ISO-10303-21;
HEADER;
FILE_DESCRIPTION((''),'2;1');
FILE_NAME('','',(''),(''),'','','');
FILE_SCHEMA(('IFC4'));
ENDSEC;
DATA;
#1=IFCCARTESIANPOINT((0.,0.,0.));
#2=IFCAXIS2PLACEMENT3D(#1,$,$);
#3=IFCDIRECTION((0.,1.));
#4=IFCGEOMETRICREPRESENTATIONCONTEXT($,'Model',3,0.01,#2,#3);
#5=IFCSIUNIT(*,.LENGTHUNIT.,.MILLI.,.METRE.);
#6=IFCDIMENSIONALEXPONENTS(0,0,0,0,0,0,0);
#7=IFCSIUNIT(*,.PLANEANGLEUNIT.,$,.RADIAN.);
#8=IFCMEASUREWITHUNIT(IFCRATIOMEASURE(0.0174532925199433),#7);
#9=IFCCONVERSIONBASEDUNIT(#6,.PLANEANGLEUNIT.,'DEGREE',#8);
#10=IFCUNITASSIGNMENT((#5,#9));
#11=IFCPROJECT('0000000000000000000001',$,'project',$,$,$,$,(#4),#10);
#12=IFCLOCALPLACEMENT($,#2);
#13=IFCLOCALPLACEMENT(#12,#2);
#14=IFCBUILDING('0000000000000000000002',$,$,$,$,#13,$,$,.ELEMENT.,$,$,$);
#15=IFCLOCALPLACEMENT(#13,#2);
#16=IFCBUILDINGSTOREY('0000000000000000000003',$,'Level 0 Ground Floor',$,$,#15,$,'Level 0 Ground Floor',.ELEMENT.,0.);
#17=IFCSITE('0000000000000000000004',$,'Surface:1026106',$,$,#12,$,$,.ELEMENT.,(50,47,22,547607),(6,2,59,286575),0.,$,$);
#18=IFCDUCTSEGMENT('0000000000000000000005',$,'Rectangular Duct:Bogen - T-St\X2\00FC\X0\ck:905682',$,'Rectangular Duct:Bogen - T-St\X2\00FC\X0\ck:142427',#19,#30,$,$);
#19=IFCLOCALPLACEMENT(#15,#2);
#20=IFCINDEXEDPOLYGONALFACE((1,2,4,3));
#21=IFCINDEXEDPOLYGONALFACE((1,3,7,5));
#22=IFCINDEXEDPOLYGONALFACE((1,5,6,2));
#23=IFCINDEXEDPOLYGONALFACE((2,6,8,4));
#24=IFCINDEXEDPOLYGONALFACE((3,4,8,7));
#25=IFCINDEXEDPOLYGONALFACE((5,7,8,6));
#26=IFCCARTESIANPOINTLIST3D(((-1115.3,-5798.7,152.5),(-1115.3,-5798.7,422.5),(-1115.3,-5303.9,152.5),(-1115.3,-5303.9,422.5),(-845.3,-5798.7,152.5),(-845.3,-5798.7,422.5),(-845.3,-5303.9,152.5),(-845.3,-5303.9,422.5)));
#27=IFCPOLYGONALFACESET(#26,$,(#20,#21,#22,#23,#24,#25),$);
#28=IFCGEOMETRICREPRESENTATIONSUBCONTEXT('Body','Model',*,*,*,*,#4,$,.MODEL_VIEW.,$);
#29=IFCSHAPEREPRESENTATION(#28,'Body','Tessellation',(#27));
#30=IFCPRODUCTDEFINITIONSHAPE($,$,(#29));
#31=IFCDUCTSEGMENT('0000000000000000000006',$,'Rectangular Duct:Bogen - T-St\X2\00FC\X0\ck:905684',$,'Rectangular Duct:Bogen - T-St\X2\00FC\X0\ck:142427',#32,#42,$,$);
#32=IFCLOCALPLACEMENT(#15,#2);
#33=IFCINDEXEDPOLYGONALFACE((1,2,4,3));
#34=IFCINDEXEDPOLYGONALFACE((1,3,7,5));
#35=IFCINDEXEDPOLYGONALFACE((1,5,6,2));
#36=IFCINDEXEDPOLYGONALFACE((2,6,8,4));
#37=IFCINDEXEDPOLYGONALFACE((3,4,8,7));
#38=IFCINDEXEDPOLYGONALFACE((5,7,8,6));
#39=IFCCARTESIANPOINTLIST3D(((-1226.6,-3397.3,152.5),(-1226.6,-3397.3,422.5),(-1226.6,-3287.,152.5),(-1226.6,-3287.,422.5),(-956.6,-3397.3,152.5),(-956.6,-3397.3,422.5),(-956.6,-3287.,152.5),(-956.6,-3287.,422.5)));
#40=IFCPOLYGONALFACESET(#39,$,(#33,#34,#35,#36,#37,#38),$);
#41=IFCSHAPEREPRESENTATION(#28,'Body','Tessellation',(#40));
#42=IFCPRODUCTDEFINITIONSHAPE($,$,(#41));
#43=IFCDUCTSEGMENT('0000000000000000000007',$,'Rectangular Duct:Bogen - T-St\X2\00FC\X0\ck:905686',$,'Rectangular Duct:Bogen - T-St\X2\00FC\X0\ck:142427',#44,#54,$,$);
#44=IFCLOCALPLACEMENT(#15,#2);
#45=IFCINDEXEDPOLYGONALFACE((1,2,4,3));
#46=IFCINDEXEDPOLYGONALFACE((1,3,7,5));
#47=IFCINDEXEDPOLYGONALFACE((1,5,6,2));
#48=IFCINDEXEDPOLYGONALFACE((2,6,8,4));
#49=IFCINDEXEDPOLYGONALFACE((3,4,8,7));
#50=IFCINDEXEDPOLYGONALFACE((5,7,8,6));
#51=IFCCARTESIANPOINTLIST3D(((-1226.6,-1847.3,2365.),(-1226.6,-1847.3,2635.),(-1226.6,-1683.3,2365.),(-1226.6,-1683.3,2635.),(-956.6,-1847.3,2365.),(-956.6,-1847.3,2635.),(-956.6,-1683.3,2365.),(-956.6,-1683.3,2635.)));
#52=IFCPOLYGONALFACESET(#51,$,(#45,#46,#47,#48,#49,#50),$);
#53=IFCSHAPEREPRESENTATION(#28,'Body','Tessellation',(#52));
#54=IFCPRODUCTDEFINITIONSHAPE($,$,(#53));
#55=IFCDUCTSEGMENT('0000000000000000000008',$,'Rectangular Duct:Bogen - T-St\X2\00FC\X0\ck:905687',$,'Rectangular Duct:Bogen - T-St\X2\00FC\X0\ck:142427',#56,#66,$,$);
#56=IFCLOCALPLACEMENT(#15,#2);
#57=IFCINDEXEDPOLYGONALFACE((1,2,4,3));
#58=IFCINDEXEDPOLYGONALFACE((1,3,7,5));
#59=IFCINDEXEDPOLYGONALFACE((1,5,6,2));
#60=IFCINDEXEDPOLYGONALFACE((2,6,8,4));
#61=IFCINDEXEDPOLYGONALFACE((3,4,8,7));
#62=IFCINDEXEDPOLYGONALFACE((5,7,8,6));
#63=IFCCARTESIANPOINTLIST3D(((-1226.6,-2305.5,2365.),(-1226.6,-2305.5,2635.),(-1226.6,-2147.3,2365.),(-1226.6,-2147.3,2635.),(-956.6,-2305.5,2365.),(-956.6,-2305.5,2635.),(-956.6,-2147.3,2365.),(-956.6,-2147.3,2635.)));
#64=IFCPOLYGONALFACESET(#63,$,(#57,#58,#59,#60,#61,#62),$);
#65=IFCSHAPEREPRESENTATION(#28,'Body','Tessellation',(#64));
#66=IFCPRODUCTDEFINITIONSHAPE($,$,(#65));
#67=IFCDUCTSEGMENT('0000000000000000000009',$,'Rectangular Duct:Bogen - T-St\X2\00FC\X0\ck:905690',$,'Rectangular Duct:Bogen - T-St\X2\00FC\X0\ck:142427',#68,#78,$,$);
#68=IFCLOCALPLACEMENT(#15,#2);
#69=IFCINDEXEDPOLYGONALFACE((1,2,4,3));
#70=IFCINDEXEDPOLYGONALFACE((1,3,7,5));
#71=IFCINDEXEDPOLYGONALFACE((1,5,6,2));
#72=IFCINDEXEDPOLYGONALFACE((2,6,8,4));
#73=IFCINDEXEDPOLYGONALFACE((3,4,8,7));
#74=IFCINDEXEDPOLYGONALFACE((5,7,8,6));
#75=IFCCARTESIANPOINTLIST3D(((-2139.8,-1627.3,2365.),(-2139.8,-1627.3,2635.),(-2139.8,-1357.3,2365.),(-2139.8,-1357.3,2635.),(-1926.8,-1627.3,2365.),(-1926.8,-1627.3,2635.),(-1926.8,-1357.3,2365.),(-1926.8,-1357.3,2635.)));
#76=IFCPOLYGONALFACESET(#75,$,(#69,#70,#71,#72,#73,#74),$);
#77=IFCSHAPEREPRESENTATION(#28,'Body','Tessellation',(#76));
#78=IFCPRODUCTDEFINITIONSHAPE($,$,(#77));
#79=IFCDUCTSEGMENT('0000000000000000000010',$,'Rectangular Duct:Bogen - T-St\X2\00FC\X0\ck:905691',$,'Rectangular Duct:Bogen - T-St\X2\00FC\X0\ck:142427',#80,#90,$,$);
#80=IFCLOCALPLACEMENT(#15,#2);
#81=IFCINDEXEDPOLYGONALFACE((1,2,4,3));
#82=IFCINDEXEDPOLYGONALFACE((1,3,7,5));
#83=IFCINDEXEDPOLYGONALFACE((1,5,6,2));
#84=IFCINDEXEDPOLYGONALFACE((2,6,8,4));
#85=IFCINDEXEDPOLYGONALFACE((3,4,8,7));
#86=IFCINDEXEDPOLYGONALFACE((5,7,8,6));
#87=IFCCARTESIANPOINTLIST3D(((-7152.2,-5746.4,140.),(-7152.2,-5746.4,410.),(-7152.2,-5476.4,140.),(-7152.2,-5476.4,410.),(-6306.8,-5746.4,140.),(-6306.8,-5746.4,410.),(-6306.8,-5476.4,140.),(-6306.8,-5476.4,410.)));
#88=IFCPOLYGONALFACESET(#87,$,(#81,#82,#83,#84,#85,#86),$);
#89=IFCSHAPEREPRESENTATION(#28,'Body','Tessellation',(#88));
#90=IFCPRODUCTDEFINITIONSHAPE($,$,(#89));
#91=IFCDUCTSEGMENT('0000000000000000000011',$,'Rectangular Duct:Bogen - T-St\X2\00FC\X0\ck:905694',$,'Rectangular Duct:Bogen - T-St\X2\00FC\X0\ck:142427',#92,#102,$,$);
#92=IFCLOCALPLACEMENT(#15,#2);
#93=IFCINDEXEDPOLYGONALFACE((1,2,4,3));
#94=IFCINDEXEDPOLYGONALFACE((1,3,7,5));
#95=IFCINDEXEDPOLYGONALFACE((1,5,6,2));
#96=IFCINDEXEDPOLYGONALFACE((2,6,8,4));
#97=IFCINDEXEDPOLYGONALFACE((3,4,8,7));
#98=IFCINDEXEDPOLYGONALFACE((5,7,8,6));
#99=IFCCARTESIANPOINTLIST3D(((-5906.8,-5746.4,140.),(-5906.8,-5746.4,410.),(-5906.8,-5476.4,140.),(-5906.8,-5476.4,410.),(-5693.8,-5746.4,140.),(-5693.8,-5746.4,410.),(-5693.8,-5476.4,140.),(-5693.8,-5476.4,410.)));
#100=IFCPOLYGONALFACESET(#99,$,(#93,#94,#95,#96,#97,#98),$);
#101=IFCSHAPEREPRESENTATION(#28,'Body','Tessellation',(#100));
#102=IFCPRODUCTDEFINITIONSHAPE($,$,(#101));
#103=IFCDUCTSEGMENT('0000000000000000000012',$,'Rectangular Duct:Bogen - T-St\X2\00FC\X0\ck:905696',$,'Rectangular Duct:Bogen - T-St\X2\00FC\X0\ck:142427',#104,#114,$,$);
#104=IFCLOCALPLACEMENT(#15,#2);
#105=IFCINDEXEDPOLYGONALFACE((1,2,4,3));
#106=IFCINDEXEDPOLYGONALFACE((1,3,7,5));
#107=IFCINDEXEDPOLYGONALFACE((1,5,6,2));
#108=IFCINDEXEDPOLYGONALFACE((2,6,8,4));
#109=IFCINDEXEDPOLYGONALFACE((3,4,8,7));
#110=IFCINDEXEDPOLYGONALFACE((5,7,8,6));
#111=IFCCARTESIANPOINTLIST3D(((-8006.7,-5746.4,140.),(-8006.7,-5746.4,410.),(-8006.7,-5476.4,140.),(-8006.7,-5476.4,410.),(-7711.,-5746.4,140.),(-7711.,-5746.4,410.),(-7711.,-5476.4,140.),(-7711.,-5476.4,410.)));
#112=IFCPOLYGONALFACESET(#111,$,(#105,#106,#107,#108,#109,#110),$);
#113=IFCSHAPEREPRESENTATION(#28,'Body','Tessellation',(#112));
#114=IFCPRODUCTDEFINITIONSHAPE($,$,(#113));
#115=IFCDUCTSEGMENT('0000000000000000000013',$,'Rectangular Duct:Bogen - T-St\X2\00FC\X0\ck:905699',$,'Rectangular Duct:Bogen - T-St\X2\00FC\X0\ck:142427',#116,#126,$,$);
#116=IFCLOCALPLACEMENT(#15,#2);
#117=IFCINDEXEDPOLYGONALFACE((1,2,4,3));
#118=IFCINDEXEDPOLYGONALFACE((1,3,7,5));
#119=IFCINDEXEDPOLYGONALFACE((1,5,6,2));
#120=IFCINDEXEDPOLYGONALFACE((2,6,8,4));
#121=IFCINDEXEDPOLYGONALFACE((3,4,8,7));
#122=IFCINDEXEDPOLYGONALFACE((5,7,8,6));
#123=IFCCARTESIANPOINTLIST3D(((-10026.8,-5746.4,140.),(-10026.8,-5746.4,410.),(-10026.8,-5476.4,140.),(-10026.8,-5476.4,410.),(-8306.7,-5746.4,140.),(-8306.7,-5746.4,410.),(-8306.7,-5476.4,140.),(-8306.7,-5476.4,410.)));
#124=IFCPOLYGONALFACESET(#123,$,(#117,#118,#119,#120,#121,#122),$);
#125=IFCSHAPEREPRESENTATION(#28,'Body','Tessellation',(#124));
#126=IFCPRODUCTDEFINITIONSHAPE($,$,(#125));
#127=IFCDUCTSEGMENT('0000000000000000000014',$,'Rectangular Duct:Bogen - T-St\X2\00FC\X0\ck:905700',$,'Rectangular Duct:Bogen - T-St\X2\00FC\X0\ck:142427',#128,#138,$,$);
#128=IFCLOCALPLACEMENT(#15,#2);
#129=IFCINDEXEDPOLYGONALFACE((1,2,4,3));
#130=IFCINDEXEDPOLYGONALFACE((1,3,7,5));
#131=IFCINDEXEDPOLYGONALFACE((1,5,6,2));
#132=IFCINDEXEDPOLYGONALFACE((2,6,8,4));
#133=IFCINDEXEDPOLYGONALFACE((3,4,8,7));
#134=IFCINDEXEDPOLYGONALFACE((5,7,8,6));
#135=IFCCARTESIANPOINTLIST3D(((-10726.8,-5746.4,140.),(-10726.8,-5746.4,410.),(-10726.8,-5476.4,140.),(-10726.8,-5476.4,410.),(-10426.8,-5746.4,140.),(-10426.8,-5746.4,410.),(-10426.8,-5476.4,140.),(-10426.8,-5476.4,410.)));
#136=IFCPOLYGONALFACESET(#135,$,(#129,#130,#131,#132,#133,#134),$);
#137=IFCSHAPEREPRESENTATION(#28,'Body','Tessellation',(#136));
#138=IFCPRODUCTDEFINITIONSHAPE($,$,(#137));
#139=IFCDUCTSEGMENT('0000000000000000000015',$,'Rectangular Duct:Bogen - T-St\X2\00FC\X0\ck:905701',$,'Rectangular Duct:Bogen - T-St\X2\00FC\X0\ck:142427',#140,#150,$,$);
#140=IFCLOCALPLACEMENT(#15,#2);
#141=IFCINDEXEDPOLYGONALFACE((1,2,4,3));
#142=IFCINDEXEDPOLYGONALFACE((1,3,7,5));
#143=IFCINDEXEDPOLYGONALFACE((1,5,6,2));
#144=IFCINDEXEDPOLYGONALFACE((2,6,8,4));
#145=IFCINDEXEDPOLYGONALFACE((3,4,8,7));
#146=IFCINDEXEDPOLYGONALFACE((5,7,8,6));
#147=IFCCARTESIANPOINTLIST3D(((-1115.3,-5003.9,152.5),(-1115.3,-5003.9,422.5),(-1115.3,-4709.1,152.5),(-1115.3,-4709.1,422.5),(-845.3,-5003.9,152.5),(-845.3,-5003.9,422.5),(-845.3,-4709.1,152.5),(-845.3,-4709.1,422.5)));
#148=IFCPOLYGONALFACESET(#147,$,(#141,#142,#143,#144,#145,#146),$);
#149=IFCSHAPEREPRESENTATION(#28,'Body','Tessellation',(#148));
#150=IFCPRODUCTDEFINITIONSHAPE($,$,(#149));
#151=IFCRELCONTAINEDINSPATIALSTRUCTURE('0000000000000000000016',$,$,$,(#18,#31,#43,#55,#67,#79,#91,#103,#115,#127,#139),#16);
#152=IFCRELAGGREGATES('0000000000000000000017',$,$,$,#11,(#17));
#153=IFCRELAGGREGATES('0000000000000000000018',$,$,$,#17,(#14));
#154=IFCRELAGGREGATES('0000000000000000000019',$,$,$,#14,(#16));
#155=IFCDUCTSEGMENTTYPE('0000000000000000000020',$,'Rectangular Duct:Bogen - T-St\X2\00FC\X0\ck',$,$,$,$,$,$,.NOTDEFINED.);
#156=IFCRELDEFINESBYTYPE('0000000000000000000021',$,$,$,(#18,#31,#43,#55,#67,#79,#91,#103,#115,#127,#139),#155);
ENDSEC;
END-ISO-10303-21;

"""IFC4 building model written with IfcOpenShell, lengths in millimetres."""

from ifc_helpers import new_model, entity, si_unit, converted_unit, direction, frame, frame_2d, origin, origin_2d_with_axis, place, context, subcontext, project, spatial, rectangle, extrude, type_object, element, save


model = new_model("IFC4")

# Units and contexts
model_context = context("Model", 3, precision=0.01, world=origin(), true_north=direction((0.0, 1.0)))
body_context = subcontext(model_context, "Body", "Model", "MODEL_VIEW")
ifc_project = project(units=[si_unit("LENGTHUNIT", "METRE", prefix="MILLI"), converted_unit("PLANEANGLEUNIT", "DEGREE", entity("IfcRatioMeasure", 0.0174532925199433), si_unit("PLANEANGLEUNIT", "RADIAN"), dimensions=[0, 0, 0, 0, 0, 0, 0])], contexts=[model_context])

# Site, building, storey
site_placement = place(None, origin())
site = spatial("IfcSite", under=ifc_project, at=site_placement, Name="Surface:1026106", CompositionType="ELEMENT", RefLatitude=(50, 47, 22, 547607), RefLongitude=(6, 2, 59, 286575), RefElevation=0.0)
building_placement = place(site_placement, origin())
building = spatial("IfcBuilding", under=site, at=building_placement, CompositionType="ELEMENT")
storey_placement = place(building_placement, origin())
storey = spatial("IfcBuildingStorey", under=building, at=storey_placement, Name="Level 0 Ground Floor", LongName="Level 0 Ground Floor", CompositionType="ELEMENT", Elevation=0.0)

# Duct segments
duct_segment_type = type_object("IfcDuctSegmentType", Name="Rectangular Duct:Bogen - T-Stück", PredefinedType="NOTDEFINED")
duct_segment_1_placement = place(storey_placement, frame((-1115.3, -5798.7, 152.5)))
element("IfcDuctSegment", 1, at=duct_segment_1_placement, inside=storey, type_object=duct_segment_type, Name="Rectangular Duct:Bogen - T-Stück:905682", ObjectType="Rectangular Duct:Bogen - T-Stück:142427", context=body_context, shape_type="SweptSolid", body=[
    extrude(rectangle(XDim=494.8, YDim=270.0, at=frame_2d((0.0, 0.0), x_axis=(1.0, 0.0))), frame((135.0, 247.4, 0.0), z_axis=(0.0, 0.0, 1.0), x_axis=(0.0, -1.0, 0.0)), (0.0, 0.0, 1.0), 270.0),
])
duct_segment_2_placement = place(storey_placement, frame((-1226.6, -3397.3, 152.5)))
element("IfcDuctSegment", 2, at=duct_segment_2_placement, inside=storey, type_object=duct_segment_type, Name="Rectangular Duct:Bogen - T-Stück:905684", ObjectType="Rectangular Duct:Bogen - T-Stück:142427", context=body_context, shape_type="SweptSolid", body=[
    extrude(rectangle(XDim=110.2, YDim=270.0, at=origin_2d_with_axis()), frame((135.0, 55.1, 0.0), z_axis=(0.0, 0.0, 1.0), x_axis=(0.0, 1.0, 0.0)), (0.0, 0.0, 1.0), 270.0),
])
duct_segment_3_placement = place(storey_placement, frame((-1226.6, -1847.3, 2365.0)))
element("IfcDuctSegment", 3, at=duct_segment_3_placement, inside=storey, type_object=duct_segment_type, Name="Rectangular Duct:Bogen - T-Stück:905686", ObjectType="Rectangular Duct:Bogen - T-Stück:142427", context=body_context, shape_type="SweptSolid", body=[
    extrude(rectangle(XDim=164.0, YDim=270.0, at=frame_2d((0.0, 0.0), x_axis=(1.0, 0.0))), frame((135.0, 82.0, 0.0), z_axis=(0.0, 0.0, 1.0), x_axis=(0.0, -1.0, 0.0)), (0.0, 0.0, 1.0), 270.0),
])
duct_segment_4_placement = place(storey_placement, frame((-1226.6, -2305.5, 2365.0)))
element("IfcDuctSegment", 4, at=duct_segment_4_placement, inside=storey, type_object=duct_segment_type, Name="Rectangular Duct:Bogen - T-Stück:905687", ObjectType="Rectangular Duct:Bogen - T-Stück:142427", context=body_context, shape_type="SweptSolid", body=[
    extrude(rectangle(XDim=158.2, YDim=270.0, at=frame_2d((0.0, 0.0), x_axis=(1.0, 0.0))), frame((135.0, 79.1, 0.0), z_axis=(0.0, 0.0, 1.0), x_axis=(0.0, 1.0, 0.0)), (0.0, 0.0, 1.0), 270.0),
])
duct_segment_5_placement = place(storey_placement, frame((-2139.8, -1627.3, 2365.0)))
element("IfcDuctSegment", 5, at=duct_segment_5_placement, inside=storey, type_object=duct_segment_type, Name="Rectangular Duct:Bogen - T-Stück:905690", ObjectType="Rectangular Duct:Bogen - T-Stück:142427", context=body_context, shape_type="SweptSolid", body=[
    extrude(rectangle(XDim=213.0, YDim=270.0, at=origin_2d_with_axis()), frame((106.5, 135.0, 0.0)), (0.0, 0.0, 1.0), 270.0),
])
duct_segment_6_placement = place(storey_placement, frame((-7152.2, -5746.4, 140.0)))
element("IfcDuctSegment", 6, at=duct_segment_6_placement, inside=storey, type_object=duct_segment_type, Name="Rectangular Duct:Bogen - T-Stück:905691", ObjectType="Rectangular Duct:Bogen - T-Stück:142427", context=body_context, shape_type="SweptSolid", body=[
    extrude(rectangle(XDim=845.4, YDim=270.0, at=frame_2d((0.0, 0.0), x_axis=(1.0, 0.0))), frame((422.7, 135.0, 0.0), z_axis=(0.0, 0.0, 1.0), x_axis=(-1.0, 0.0, 0.0)), (0.0, 0.0, 1.0), 270.0),
])
duct_segment_7_placement = place(storey_placement, frame((-5906.8, -5746.4, 140.0)))
element("IfcDuctSegment", 7, at=duct_segment_7_placement, inside=storey, type_object=duct_segment_type, Name="Rectangular Duct:Bogen - T-Stück:905694", ObjectType="Rectangular Duct:Bogen - T-Stück:142427", context=body_context, shape_type="SweptSolid", body=[
    extrude(rectangle(XDim=213.0, YDim=270.0, at=frame_2d((0.0, 0.0), x_axis=(1.0, 0.0))), frame((106.5, 135.0, 0.0), z_axis=(0.0, 0.0, 1.0), x_axis=(-1.0, 0.0, 0.0)), (0.0, 0.0, 1.0), 270.0),
])
duct_segment_8_placement = place(storey_placement, frame((-8006.7, -5746.4, 140.0)))
element("IfcDuctSegment", 8, at=duct_segment_8_placement, inside=storey, type_object=duct_segment_type, Name="Rectangular Duct:Bogen - T-Stück:905696", ObjectType="Rectangular Duct:Bogen - T-Stück:142427", context=body_context, shape_type="SweptSolid", body=[
    extrude(rectangle(XDim=295.7, YDim=270.0, at=frame_2d((0.0, 0.0), x_axis=(1.0, 0.0))), frame((147.8, 135.0, 0.0)), (0.0, 0.0, 1.0), 270.0),
])
duct_segment_9_placement = place(storey_placement, frame((-10026.8, -5746.4, 140.0)))
element("IfcDuctSegment", 9, at=duct_segment_9_placement, inside=storey, type_object=duct_segment_type, Name="Rectangular Duct:Bogen - T-Stück:905699", ObjectType="Rectangular Duct:Bogen - T-Stück:142427", context=body_context, shape_type="SweptSolid", body=[
    extrude(rectangle(XDim=1720.1, YDim=270.0, at=frame_2d((0.0, 0.0), x_axis=(1.0, 0.0))), frame((860.0, 135.0, 0.0)), (0.0, 0.0, 1.0), 270.0),
])
duct_segment_10_placement = place(storey_placement, frame((-10726.8, -5746.4, 140.0)))
element("IfcDuctSegment", 10, at=duct_segment_10_placement, inside=storey, type_object=duct_segment_type, Name="Rectangular Duct:Bogen - T-Stück:905700", ObjectType="Rectangular Duct:Bogen - T-Stück:142427", context=body_context, shape_type="SweptSolid", body=[
    extrude(rectangle(XDim=300.0, YDim=270.0, at=frame_2d((0.0, 0.0), x_axis=(1.0, 0.0))), frame((150.0, 135.0, 0.0)), (0.0, 0.0, 1.0), 270.0),
])
duct_segment_11_placement = place(storey_placement, frame((-1115.3, -5003.9, 152.5)))
element("IfcDuctSegment", 11, at=duct_segment_11_placement, inside=storey, type_object=duct_segment_type, Name="Rectangular Duct:Bogen - T-Stück:905701", ObjectType="Rectangular Duct:Bogen - T-Stück:142427", context=body_context, shape_type="SweptSolid", body=[
    extrude(rectangle(XDim=294.8, YDim=270.0, at=frame_2d((0.0, 0.0), x_axis=(1.0, 0.0))), frame((135.0, 147.4, 0.0), z_axis=(0.0, 0.0, 1.0), x_axis=(0.0, -1.0, 0.0)), (0.0, 0.0, 1.0), 270.0),
])

save(model, "model.ifc")
